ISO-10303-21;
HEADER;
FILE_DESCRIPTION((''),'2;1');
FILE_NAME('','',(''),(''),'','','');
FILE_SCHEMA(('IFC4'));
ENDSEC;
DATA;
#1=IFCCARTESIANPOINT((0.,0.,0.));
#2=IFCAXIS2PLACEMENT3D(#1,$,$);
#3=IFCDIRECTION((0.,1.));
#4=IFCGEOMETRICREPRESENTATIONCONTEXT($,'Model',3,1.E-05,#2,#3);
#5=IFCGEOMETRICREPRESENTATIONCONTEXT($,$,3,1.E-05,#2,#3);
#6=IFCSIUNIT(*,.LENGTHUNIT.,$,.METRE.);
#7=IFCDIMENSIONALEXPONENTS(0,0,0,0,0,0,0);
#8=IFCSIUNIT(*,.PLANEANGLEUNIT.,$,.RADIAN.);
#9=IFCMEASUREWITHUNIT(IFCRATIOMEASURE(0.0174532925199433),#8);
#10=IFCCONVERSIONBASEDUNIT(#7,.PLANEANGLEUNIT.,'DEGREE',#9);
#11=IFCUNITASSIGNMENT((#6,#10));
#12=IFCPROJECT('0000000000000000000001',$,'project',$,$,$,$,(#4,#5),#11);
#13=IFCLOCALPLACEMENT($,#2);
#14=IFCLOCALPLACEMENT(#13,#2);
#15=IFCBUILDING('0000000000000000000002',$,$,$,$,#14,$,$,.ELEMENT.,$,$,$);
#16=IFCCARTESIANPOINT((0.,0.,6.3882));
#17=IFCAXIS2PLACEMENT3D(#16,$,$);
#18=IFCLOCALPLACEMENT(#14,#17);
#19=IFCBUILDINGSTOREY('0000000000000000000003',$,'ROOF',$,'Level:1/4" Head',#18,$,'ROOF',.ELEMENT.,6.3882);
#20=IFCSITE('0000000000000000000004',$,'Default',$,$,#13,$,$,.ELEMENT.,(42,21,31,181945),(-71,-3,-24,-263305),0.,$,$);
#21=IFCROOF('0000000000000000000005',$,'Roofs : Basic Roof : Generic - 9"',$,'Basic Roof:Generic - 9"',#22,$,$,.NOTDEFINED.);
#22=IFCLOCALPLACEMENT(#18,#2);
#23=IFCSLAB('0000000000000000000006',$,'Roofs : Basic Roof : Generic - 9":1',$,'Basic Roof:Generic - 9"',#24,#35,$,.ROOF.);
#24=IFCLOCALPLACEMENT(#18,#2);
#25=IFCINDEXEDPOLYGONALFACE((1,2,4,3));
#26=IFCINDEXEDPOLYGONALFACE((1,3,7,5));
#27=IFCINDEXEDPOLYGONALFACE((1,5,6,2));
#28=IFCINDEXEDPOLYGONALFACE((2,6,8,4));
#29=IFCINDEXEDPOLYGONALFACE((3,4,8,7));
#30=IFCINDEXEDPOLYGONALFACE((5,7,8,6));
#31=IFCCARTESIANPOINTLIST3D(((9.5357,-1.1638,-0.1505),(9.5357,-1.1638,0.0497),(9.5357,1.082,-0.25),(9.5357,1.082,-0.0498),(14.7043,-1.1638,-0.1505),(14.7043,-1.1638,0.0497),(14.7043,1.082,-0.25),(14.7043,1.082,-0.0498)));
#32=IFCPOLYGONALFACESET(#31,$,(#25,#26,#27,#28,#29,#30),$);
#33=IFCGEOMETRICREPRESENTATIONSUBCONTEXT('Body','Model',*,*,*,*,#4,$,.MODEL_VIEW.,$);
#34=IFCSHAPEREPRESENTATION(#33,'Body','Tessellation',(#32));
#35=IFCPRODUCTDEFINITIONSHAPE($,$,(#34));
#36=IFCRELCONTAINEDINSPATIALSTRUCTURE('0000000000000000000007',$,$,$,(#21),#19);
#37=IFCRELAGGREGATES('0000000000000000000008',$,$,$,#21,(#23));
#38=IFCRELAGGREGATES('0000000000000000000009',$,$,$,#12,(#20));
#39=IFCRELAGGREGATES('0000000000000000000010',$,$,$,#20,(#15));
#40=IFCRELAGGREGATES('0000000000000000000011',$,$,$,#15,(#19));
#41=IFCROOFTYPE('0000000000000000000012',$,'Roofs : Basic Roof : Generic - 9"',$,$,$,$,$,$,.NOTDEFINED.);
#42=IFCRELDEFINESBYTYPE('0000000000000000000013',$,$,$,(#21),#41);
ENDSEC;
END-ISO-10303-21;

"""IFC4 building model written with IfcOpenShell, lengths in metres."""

from ifc_helpers import new_model, entity, si_unit, converted_unit, direction, frame, frame_2d, origin, place, context, subcontext, project, spatial, rectangle, extrude, type_object, element, aggregate, save


model = new_model("IFC4")

# Units and contexts
model_context = context("Model", 3, precision=1e-05, world=origin(), true_north=direction((0.0, 1.0)))
context_of_model = context(None, 3, precision=1e-05, world=origin(), true_north=direction((0.0, 1.0)))
body_context = subcontext(model_context, "Body", "Model", "MODEL_VIEW")
ifc_project = project(units=[si_unit("LENGTHUNIT", "METRE"), converted_unit("PLANEANGLEUNIT", "DEGREE", entity("IfcRatioMeasure", 0.0174532925199433), si_unit("PLANEANGLEUNIT", "RADIAN"), dimensions=[0, 0, 0, 0, 0, 0, 0])], contexts=[model_context, context_of_model])

# Site, building, storey
site_placement = place(None, origin())
site = spatial("IfcSite", under=ifc_project, at=site_placement, Name="Default", CompositionType="ELEMENT", RefLatitude=(42, 21, 31, 181945), RefLongitude=(-71, -3, -24, -263305), RefElevation=0.0)
building_placement = place(site_placement, origin())
building = spatial("IfcBuilding", under=site, at=building_placement, CompositionType="ELEMENT")
storey_placement = place(building_placement, frame((0.0, 0.0, 6.3882)))
storey = spatial("IfcBuildingStorey", under=building, at=storey_placement, Name="ROOF", ObjectType="Level:1/4\" Head", LongName="ROOF", CompositionType="ELEMENT", Elevation=6.3882)

# Roof, slab, opening
roof_type = type_object("IfcRoofType", Name="Roofs : Basic Roof : Generic - 9\"", PredefinedType="NOTDEFINED")
roof_placement = place(storey_placement, frame((9.5357, -1.1638, -0.25)))
roof = element("IfcRoof", 1, at=roof_placement, inside=storey, type_object=roof_type, Name="Roofs : Basic Roof : Generic - 9\"", ObjectType="Basic Roof:Generic - 9\"", PredefinedType="NOTDEFINED")
slab_placement = place(storey_placement, frame((9.5357, -1.1638, -0.25)))
slab = element("IfcSlab", 2, at=slab_placement, Name="Roofs : Basic Roof : Generic - 9\":1", ObjectType="Basic Roof:Generic - 9\"", PredefinedType="ROOF", context=body_context, shape_type="SweptSolid", body=[
    extrude(rectangle(XDim=2.248, YDim=5.1686, at=frame_2d((0.0, 0.0), x_axis=(0.0, 1.0))), frame((2.5843, 1.1229, 0.0498), z_axis=(0.0, 0.044281, 0.999019), x_axis=(1.0, 0.0, 0.0)), (0.0, -0.044281, 0.999019), 0.2002),
])
opening_placement = place(storey_placement, frame((9.5357, -1.1638, -0.25)))
element("IfcOpeningElement", 3, at=opening_placement, cuts=slab, ObjectType="Opening", PredefinedType="OPENING", context=body_context, shape_type="SweptSolid", body=[
    extrude(rectangle(XDim=0.373, YDim=0.973, at=frame_2d((0.0, 0.0), x_axis=(0.0, 1.0))), frame((7.9657, 0.4055, 0.0721), z_axis=(0.0, -0.044281, -0.999019), x_axis=(-1.0, 0.0, 0.0)), (0.0, 0.0, 1.0), 0.2),
])
aggregate(roof, [slab])

save(model, "model.ifc")
